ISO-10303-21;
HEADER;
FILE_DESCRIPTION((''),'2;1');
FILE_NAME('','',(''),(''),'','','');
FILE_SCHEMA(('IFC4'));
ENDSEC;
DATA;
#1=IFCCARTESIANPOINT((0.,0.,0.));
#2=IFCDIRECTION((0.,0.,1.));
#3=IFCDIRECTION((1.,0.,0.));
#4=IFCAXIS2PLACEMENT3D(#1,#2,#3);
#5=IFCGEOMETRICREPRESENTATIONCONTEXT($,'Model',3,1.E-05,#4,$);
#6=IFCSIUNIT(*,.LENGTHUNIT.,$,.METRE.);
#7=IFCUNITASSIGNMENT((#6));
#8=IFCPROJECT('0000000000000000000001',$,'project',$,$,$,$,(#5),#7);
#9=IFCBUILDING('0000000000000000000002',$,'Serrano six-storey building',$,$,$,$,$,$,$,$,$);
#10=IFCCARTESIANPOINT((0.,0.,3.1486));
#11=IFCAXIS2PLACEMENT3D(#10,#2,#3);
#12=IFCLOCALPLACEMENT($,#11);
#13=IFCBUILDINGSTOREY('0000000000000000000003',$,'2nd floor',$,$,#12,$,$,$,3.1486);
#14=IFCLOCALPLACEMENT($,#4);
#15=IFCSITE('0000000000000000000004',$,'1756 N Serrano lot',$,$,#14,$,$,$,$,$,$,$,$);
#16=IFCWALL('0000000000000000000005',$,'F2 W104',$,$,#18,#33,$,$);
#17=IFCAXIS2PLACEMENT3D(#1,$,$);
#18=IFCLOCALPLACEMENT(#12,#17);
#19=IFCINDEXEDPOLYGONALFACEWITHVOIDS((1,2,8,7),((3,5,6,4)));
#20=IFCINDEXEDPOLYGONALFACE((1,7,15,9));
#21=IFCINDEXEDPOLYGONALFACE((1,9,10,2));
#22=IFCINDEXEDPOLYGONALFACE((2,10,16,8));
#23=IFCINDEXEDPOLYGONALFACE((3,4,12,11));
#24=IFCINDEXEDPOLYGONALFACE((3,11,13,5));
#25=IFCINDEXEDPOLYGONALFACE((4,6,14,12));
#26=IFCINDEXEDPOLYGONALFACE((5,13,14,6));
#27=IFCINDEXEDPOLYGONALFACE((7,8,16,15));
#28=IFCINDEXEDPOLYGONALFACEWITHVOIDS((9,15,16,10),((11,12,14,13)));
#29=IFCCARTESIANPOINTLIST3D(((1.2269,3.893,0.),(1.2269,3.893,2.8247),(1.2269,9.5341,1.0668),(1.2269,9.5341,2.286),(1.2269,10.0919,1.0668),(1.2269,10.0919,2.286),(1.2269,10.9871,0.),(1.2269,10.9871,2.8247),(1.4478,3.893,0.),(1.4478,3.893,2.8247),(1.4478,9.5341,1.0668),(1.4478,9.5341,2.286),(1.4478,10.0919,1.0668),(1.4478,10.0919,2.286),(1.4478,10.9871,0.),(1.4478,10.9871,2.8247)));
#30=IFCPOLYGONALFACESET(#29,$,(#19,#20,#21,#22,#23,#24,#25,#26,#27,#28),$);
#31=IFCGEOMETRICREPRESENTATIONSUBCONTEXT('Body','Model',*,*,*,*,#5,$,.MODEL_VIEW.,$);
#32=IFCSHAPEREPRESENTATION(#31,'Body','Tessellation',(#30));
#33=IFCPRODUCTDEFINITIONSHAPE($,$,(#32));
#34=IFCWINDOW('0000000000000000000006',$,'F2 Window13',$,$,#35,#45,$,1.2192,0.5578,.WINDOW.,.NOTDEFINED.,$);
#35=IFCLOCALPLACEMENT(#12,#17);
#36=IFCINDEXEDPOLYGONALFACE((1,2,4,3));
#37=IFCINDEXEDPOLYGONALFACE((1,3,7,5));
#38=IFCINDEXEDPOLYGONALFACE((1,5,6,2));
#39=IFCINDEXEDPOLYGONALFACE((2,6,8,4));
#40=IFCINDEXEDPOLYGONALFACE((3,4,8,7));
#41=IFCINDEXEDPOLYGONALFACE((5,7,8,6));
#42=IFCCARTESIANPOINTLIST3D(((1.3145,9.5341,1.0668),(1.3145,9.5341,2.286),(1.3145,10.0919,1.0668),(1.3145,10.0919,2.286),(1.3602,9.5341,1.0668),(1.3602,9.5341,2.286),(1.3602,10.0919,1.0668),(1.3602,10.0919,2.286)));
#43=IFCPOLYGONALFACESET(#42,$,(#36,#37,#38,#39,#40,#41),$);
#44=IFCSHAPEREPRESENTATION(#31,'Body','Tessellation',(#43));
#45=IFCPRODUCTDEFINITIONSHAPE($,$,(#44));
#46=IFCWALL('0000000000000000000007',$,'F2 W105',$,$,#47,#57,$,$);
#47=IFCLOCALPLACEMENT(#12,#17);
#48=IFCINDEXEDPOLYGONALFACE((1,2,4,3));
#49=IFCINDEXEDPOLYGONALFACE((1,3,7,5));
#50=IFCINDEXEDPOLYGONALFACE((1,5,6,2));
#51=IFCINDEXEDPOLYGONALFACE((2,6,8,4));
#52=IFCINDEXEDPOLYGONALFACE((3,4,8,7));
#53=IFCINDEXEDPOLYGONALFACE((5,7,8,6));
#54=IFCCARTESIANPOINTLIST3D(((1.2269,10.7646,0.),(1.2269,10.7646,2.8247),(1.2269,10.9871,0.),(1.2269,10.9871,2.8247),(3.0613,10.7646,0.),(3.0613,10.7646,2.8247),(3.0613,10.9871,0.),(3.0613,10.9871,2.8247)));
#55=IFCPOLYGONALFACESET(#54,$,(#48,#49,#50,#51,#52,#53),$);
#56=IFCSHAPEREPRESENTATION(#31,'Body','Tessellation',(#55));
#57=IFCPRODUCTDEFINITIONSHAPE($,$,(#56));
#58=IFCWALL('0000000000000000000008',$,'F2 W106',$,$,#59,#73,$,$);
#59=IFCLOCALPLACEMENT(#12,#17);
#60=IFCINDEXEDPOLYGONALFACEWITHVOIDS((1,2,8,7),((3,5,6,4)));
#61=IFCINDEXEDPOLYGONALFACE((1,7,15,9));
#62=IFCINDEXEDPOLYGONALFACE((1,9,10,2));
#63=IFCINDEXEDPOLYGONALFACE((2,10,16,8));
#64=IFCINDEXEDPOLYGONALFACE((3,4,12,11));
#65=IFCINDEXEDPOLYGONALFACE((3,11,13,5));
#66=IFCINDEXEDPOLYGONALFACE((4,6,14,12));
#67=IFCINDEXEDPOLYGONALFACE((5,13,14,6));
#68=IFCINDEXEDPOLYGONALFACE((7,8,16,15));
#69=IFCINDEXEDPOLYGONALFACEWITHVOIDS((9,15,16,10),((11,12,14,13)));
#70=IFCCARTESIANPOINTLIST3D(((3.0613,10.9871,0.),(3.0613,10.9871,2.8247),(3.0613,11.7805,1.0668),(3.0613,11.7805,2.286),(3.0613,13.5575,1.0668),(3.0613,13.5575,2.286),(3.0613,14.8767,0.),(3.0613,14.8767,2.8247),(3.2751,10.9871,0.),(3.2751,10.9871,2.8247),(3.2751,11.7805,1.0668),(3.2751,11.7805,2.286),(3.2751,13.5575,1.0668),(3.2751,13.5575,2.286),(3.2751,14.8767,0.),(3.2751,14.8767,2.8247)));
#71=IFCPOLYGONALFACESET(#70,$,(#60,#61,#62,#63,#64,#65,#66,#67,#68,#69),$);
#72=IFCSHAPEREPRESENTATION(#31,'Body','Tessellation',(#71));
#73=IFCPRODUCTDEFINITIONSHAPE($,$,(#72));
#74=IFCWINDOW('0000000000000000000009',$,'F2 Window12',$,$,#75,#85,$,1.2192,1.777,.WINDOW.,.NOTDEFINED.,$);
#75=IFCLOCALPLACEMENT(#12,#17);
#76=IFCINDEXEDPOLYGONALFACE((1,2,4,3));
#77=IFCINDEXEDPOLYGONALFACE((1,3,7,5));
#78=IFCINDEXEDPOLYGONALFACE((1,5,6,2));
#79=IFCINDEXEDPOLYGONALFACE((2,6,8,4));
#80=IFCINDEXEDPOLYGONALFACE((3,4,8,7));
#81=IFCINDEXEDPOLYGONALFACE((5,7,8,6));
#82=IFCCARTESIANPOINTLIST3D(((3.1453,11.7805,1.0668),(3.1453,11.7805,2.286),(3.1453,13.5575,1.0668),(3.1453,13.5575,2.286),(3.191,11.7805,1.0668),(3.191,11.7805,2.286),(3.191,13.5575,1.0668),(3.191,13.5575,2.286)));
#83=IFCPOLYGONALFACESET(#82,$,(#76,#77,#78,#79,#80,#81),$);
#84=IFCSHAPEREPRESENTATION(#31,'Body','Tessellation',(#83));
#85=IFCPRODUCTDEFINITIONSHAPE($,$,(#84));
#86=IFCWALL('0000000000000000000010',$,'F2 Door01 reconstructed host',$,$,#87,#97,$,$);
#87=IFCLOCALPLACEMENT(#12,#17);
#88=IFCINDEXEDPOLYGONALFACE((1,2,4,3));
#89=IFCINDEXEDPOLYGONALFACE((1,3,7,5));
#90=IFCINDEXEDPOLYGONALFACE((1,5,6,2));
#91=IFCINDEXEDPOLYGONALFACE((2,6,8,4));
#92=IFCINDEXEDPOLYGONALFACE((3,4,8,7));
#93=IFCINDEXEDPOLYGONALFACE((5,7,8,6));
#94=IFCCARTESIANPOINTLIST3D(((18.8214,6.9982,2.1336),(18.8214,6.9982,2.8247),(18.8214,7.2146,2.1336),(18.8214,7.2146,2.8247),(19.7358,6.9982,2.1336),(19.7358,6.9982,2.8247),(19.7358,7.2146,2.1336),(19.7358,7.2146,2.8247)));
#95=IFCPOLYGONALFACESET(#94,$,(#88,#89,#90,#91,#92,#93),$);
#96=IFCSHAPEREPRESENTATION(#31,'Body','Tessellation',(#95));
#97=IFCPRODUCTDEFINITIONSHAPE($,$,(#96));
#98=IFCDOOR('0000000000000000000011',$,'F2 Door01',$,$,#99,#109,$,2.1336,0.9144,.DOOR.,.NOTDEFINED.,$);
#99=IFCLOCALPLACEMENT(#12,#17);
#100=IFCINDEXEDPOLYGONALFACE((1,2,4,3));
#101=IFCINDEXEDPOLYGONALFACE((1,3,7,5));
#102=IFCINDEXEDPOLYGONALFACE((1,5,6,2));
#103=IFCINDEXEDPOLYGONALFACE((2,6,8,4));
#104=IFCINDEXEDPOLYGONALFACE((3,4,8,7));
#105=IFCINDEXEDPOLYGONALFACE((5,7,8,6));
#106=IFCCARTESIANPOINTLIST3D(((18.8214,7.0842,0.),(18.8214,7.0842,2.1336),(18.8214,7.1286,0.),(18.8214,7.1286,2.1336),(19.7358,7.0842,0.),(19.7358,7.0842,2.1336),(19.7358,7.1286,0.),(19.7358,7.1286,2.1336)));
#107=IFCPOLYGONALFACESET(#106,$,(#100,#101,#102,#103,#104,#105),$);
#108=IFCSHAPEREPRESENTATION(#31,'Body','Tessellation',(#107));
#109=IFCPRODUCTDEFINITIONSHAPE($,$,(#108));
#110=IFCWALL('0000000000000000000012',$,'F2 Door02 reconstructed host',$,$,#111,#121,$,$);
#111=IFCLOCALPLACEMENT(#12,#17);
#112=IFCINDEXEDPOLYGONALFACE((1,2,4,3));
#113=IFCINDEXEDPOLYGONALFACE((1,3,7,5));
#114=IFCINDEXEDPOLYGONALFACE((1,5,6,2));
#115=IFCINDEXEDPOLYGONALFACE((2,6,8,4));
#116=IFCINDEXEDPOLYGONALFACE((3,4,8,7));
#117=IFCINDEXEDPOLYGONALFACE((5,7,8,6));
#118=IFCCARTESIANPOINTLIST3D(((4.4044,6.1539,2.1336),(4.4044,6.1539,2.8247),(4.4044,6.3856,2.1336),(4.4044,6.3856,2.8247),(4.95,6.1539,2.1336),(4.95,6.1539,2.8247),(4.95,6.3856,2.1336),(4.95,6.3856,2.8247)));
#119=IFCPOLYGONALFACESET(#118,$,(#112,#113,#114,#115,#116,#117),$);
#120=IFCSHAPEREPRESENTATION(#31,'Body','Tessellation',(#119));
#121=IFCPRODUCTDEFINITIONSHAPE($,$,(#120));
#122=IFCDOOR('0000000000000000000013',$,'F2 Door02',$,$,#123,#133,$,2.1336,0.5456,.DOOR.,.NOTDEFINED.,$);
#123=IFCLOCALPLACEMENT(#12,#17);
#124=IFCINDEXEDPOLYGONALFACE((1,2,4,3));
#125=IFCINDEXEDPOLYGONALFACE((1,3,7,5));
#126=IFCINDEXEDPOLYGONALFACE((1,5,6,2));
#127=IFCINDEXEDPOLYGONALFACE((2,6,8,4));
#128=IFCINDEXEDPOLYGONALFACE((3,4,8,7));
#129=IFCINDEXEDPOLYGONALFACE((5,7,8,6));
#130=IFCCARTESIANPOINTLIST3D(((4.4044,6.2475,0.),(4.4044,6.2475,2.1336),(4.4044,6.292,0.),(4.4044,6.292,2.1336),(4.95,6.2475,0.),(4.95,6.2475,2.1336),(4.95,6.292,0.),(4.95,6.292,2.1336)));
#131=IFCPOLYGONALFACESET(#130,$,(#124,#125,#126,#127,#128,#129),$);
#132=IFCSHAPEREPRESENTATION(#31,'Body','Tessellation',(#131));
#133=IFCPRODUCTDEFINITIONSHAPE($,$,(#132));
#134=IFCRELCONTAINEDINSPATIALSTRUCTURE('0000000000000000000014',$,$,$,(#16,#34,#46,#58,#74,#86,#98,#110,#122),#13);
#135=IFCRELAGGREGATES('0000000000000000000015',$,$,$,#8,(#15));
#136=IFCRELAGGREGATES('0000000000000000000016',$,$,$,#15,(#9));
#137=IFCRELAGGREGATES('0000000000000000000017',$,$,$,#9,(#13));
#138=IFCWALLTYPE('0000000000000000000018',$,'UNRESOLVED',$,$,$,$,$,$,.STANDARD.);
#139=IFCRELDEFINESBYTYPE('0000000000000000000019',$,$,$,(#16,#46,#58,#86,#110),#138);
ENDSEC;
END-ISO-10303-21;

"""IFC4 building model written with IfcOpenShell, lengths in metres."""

from ifc_helpers import new_model, si_unit, frame, origin_with_axes, place, context, subcontext, project, spatial, polyline, outline, extrude, type_object, element, fill, save


model = new_model("IFC4")

# Units and contexts
model_context = context("Model", 3, precision=1e-05, world=origin_with_axes())
body_context = subcontext(model_context, "Body", "Model", "MODEL_VIEW")
ifc_project = project(units=[si_unit("LENGTHUNIT", "METRE")], contexts=[model_context])

# Site, building, storey
site_placement = place(None, origin_with_axes())
site = spatial("IfcSite", under=ifc_project, at=site_placement, Name="1756 N Serrano lot")
building = spatial("IfcBuilding", under=site, Name="Serrano six-storey building")
storey_placement = place(None, frame((0.0, 0.0, 3.1486), z_axis=(0.0, 0.0, 1.0), x_axis=(1.0, 0.0, 0.0)))
storey = spatial("IfcBuildingStorey", under=building, at=storey_placement, Name="2nd floor", Elevation=3.1486)

# Shared definitions
wall_type = type_object("IfcWallType", Name="UNRESOLVED", PredefinedType="STANDARD")

# Wall, opening, window
wall_1_placement = place(storey_placement, frame((0.0, 0.0, -3.1486), z_axis=(0.0, 0.0, 1.0), x_axis=(1.0, 0.0, 0.0)))
wall_1 = element("IfcWall", 1, at=wall_1_placement, inside=storey, type_object=wall_type, Name="F2 W104", context=body_context, shape_type="SweptSolid", body=[
    extrude(outline(polyline([(1.2269, 10.9871), (1.4478, 10.9871), (1.4478, 3.893), (1.2269, 3.893), (1.2269, 10.9871)])), frame((0.0, 0.0, 3.1486)), (0.0, 0.0, 1.0), 2.8247),
])
opening_1_placement = place(None, origin_with_axes())
opening_1 = element("IfcOpeningElement", 2, at=opening_1_placement, cuts=wall_1, PredefinedType="OPENING", context=body_context, shape_type="SweptSolid", body=[
    extrude(outline(polyline([(1.2086, 10.0919), (1.4661, 10.0919), (1.4661, 9.5341), (1.2086, 9.5341), (1.2086, 10.0919)])), frame((0.0, 0.0, 4.2154)), (0.0, 0.0, 1.0), 1.2192),
])
window_1_placement = place(storey_placement, frame((0.0, 0.0, -3.1486), z_axis=(0.0, 0.0, 1.0), x_axis=(1.0, 0.0, 0.0)))
window_1 = element("IfcWindow", 3, at=window_1_placement, inside=storey, Name="F2 Window13", OverallHeight=1.2192, OverallWidth=0.5578, PartitioningType="NOTDEFINED", PredefinedType="WINDOW", context=body_context, shape_type="SweptSolid", body=[
    extrude(outline(polyline([(1.3145, 10.0919), (1.3602, 10.0919), (1.3602, 9.5341), (1.3145, 9.5341), (1.3145, 10.0919)])), frame((0.0, 0.0, 4.2154)), (0.0, 0.0, 1.0), 1.2192),
])
fill(opening_1, window_1)

# Wall
wall_2_placement = place(storey_placement, frame((0.0, 0.0, -3.1486), z_axis=(0.0, 0.0, 1.0), x_axis=(1.0, 0.0, 0.0)))
element("IfcWall", 4, at=wall_2_placement, inside=storey, type_object=wall_type, Name="F2 W105", context=body_context, shape_type="SweptSolid", body=[
    extrude(outline(polyline([(3.0613, 10.9871), (3.0613, 10.7646), (1.2269, 10.7646), (1.2269, 10.9871), (3.0613, 10.9871)])), frame((0.0, 0.0, 3.1486)), (0.0, 0.0, 1.0), 2.8247),
])

# Wall, opening, window
wall_3_placement = place(storey_placement, frame((0.0, 0.0, -3.1486), z_axis=(0.0, 0.0, 1.0), x_axis=(1.0, 0.0, 0.0)))
wall_3 = element("IfcWall", 5, at=wall_3_placement, inside=storey, type_object=wall_type, Name="F2 W106", context=body_context, shape_type="SweptSolid", body=[
    extrude(outline(polyline([(3.0613, 14.8767), (3.2751, 14.8767), (3.2751, 10.9871), (3.0613, 10.9871), (3.0613, 14.8767)])), frame((0.0, 0.0, 3.1486)), (0.0, 0.0, 1.0), 2.8247),
])
opening_2_placement = place(None, origin_with_axes())
opening_2 = element("IfcOpeningElement", 6, at=opening_2_placement, cuts=wall_3, PredefinedType="OPENING", context=body_context, shape_type="SweptSolid", body=[
    extrude(outline(polyline([(3.043, 13.5575), (3.2934, 13.5575), (3.2934, 11.7805), (3.043, 11.7805), (3.043, 13.5575)])), frame((0.0, 0.0, 4.2154)), (0.0, 0.0, 1.0), 1.2192),
])
window_2_placement = place(storey_placement, frame((0.0, 0.0, -3.1486), z_axis=(0.0, 0.0, 1.0), x_axis=(1.0, 0.0, 0.0)))
window_2 = element("IfcWindow", 7, at=window_2_placement, inside=storey, Name="F2 Window12", OverallHeight=1.2192, OverallWidth=1.777, PartitioningType="NOTDEFINED", PredefinedType="WINDOW", context=body_context, shape_type="SweptSolid", body=[
    extrude(outline(polyline([(3.1453, 13.5575), (3.191, 13.5575), (3.191, 11.7805), (3.1453, 11.7805), (3.1453, 13.5575)])), frame((0.0, 0.0, 4.2154)), (0.0, 0.0, 1.0), 1.2192),
])
fill(opening_2, window_2)

# Walls, openings, doors
wall_4_placement = place(storey_placement, frame((0.0, 0.0, -3.1486), z_axis=(0.0, 0.0, 1.0), x_axis=(1.0, 0.0, 0.0)))
wall_4 = element("IfcWall", 8, at=wall_4_placement, inside=storey, type_object=wall_type, Name="F2 Door01 reconstructed host", context=body_context, shape_type="SweptSolid", body=[
    extrude(outline(polyline([(18.8214, 6.9982), (18.8214, 7.2146), (19.7358, 7.2146), (19.7358, 6.9982), (18.8214, 6.9982)])), frame((0.0, 0.0, 3.1486)), (0.0, 0.0, 1.0), 2.8247),
])
opening_3_placement = place(None, origin_with_axes())
opening_3 = element("IfcOpeningElement", 9, at=opening_3_placement, cuts=wall_4, PredefinedType="OPENING", context=body_context, shape_type="SweptSolid", body=[
    extrude(outline(polyline([(18.8214, 6.9799), (18.8214, 7.2329), (19.7358, 7.2329), (19.7358, 6.9799), (18.8214, 6.9799)])), frame((0.0, 0.0, 3.1486)), (0.0, 0.0, 1.0), 2.1336),
])
door_1_placement = place(storey_placement, frame((0.0, 0.0, -3.1486), z_axis=(0.0, 0.0, 1.0), x_axis=(1.0, 0.0, 0.0)))
door_1 = element("IfcDoor", 10, at=door_1_placement, inside=storey, Name="F2 Door01", OperationType="NOTDEFINED", OverallHeight=2.1336, OverallWidth=0.9144, PredefinedType="DOOR", context=body_context, shape_type="SweptSolid", body=[
    extrude(outline(polyline([(18.8214, 7.0842), (18.8214, 7.1286), (19.7358, 7.1286), (19.7358, 7.0842), (18.8214, 7.0842)])), frame((0.0, 0.0, 3.1486)), (0.0, 0.0, 1.0), 2.1336),
])
fill(opening_3, door_1)
wall_5_placement = place(storey_placement, frame((0.0, 0.0, -3.1486), z_axis=(0.0, 0.0, 1.0), x_axis=(1.0, 0.0, 0.0)))
wall_5 = element("IfcWall", 11, at=wall_5_placement, inside=storey, type_object=wall_type, Name="F2 Door02 reconstructed host", context=body_context, shape_type="SweptSolid", body=[
    extrude(outline(polyline([(4.95, 6.3856), (4.95, 6.1539), (4.4044, 6.1539), (4.4044, 6.3856), (4.95, 6.3856)])), frame((0.0, 0.0, 3.1486)), (0.0, 0.0, 1.0), 2.8247),
])
opening_4_placement = place(None, origin_with_axes())
opening_4 = element("IfcOpeningElement", 12, at=opening_4_placement, cuts=wall_5, PredefinedType="OPENING", context=body_context, shape_type="SweptSolid", body=[
    extrude(outline(polyline([(4.95, 6.4038), (4.95, 6.1356), (4.4044, 6.1356), (4.4044, 6.4038), (4.95, 6.4038)])), frame((0.0, 0.0, 3.1486)), (0.0, 0.0, 1.0), 2.1336),
])
door_2_placement = place(storey_placement, frame((0.0, 0.0, -3.1486), z_axis=(0.0, 0.0, 1.0), x_axis=(1.0, 0.0, 0.0)))
door_2 = element("IfcDoor", 13, at=door_2_placement, inside=storey, Name="F2 Door02", OperationType="NOTDEFINED", OverallHeight=2.1336, OverallWidth=0.5456, PredefinedType="DOOR", context=body_context, shape_type="SweptSolid", body=[
    extrude(outline(polyline([(4.95, 6.292), (4.95, 6.2475), (4.4044, 6.2475), (4.4044, 6.292), (4.95, 6.292)])), frame((0.0, 0.0, 3.1486)), (0.0, 0.0, 1.0), 2.1336),
])
fill(opening_4, door_2)

save(model, "model.ifc")
